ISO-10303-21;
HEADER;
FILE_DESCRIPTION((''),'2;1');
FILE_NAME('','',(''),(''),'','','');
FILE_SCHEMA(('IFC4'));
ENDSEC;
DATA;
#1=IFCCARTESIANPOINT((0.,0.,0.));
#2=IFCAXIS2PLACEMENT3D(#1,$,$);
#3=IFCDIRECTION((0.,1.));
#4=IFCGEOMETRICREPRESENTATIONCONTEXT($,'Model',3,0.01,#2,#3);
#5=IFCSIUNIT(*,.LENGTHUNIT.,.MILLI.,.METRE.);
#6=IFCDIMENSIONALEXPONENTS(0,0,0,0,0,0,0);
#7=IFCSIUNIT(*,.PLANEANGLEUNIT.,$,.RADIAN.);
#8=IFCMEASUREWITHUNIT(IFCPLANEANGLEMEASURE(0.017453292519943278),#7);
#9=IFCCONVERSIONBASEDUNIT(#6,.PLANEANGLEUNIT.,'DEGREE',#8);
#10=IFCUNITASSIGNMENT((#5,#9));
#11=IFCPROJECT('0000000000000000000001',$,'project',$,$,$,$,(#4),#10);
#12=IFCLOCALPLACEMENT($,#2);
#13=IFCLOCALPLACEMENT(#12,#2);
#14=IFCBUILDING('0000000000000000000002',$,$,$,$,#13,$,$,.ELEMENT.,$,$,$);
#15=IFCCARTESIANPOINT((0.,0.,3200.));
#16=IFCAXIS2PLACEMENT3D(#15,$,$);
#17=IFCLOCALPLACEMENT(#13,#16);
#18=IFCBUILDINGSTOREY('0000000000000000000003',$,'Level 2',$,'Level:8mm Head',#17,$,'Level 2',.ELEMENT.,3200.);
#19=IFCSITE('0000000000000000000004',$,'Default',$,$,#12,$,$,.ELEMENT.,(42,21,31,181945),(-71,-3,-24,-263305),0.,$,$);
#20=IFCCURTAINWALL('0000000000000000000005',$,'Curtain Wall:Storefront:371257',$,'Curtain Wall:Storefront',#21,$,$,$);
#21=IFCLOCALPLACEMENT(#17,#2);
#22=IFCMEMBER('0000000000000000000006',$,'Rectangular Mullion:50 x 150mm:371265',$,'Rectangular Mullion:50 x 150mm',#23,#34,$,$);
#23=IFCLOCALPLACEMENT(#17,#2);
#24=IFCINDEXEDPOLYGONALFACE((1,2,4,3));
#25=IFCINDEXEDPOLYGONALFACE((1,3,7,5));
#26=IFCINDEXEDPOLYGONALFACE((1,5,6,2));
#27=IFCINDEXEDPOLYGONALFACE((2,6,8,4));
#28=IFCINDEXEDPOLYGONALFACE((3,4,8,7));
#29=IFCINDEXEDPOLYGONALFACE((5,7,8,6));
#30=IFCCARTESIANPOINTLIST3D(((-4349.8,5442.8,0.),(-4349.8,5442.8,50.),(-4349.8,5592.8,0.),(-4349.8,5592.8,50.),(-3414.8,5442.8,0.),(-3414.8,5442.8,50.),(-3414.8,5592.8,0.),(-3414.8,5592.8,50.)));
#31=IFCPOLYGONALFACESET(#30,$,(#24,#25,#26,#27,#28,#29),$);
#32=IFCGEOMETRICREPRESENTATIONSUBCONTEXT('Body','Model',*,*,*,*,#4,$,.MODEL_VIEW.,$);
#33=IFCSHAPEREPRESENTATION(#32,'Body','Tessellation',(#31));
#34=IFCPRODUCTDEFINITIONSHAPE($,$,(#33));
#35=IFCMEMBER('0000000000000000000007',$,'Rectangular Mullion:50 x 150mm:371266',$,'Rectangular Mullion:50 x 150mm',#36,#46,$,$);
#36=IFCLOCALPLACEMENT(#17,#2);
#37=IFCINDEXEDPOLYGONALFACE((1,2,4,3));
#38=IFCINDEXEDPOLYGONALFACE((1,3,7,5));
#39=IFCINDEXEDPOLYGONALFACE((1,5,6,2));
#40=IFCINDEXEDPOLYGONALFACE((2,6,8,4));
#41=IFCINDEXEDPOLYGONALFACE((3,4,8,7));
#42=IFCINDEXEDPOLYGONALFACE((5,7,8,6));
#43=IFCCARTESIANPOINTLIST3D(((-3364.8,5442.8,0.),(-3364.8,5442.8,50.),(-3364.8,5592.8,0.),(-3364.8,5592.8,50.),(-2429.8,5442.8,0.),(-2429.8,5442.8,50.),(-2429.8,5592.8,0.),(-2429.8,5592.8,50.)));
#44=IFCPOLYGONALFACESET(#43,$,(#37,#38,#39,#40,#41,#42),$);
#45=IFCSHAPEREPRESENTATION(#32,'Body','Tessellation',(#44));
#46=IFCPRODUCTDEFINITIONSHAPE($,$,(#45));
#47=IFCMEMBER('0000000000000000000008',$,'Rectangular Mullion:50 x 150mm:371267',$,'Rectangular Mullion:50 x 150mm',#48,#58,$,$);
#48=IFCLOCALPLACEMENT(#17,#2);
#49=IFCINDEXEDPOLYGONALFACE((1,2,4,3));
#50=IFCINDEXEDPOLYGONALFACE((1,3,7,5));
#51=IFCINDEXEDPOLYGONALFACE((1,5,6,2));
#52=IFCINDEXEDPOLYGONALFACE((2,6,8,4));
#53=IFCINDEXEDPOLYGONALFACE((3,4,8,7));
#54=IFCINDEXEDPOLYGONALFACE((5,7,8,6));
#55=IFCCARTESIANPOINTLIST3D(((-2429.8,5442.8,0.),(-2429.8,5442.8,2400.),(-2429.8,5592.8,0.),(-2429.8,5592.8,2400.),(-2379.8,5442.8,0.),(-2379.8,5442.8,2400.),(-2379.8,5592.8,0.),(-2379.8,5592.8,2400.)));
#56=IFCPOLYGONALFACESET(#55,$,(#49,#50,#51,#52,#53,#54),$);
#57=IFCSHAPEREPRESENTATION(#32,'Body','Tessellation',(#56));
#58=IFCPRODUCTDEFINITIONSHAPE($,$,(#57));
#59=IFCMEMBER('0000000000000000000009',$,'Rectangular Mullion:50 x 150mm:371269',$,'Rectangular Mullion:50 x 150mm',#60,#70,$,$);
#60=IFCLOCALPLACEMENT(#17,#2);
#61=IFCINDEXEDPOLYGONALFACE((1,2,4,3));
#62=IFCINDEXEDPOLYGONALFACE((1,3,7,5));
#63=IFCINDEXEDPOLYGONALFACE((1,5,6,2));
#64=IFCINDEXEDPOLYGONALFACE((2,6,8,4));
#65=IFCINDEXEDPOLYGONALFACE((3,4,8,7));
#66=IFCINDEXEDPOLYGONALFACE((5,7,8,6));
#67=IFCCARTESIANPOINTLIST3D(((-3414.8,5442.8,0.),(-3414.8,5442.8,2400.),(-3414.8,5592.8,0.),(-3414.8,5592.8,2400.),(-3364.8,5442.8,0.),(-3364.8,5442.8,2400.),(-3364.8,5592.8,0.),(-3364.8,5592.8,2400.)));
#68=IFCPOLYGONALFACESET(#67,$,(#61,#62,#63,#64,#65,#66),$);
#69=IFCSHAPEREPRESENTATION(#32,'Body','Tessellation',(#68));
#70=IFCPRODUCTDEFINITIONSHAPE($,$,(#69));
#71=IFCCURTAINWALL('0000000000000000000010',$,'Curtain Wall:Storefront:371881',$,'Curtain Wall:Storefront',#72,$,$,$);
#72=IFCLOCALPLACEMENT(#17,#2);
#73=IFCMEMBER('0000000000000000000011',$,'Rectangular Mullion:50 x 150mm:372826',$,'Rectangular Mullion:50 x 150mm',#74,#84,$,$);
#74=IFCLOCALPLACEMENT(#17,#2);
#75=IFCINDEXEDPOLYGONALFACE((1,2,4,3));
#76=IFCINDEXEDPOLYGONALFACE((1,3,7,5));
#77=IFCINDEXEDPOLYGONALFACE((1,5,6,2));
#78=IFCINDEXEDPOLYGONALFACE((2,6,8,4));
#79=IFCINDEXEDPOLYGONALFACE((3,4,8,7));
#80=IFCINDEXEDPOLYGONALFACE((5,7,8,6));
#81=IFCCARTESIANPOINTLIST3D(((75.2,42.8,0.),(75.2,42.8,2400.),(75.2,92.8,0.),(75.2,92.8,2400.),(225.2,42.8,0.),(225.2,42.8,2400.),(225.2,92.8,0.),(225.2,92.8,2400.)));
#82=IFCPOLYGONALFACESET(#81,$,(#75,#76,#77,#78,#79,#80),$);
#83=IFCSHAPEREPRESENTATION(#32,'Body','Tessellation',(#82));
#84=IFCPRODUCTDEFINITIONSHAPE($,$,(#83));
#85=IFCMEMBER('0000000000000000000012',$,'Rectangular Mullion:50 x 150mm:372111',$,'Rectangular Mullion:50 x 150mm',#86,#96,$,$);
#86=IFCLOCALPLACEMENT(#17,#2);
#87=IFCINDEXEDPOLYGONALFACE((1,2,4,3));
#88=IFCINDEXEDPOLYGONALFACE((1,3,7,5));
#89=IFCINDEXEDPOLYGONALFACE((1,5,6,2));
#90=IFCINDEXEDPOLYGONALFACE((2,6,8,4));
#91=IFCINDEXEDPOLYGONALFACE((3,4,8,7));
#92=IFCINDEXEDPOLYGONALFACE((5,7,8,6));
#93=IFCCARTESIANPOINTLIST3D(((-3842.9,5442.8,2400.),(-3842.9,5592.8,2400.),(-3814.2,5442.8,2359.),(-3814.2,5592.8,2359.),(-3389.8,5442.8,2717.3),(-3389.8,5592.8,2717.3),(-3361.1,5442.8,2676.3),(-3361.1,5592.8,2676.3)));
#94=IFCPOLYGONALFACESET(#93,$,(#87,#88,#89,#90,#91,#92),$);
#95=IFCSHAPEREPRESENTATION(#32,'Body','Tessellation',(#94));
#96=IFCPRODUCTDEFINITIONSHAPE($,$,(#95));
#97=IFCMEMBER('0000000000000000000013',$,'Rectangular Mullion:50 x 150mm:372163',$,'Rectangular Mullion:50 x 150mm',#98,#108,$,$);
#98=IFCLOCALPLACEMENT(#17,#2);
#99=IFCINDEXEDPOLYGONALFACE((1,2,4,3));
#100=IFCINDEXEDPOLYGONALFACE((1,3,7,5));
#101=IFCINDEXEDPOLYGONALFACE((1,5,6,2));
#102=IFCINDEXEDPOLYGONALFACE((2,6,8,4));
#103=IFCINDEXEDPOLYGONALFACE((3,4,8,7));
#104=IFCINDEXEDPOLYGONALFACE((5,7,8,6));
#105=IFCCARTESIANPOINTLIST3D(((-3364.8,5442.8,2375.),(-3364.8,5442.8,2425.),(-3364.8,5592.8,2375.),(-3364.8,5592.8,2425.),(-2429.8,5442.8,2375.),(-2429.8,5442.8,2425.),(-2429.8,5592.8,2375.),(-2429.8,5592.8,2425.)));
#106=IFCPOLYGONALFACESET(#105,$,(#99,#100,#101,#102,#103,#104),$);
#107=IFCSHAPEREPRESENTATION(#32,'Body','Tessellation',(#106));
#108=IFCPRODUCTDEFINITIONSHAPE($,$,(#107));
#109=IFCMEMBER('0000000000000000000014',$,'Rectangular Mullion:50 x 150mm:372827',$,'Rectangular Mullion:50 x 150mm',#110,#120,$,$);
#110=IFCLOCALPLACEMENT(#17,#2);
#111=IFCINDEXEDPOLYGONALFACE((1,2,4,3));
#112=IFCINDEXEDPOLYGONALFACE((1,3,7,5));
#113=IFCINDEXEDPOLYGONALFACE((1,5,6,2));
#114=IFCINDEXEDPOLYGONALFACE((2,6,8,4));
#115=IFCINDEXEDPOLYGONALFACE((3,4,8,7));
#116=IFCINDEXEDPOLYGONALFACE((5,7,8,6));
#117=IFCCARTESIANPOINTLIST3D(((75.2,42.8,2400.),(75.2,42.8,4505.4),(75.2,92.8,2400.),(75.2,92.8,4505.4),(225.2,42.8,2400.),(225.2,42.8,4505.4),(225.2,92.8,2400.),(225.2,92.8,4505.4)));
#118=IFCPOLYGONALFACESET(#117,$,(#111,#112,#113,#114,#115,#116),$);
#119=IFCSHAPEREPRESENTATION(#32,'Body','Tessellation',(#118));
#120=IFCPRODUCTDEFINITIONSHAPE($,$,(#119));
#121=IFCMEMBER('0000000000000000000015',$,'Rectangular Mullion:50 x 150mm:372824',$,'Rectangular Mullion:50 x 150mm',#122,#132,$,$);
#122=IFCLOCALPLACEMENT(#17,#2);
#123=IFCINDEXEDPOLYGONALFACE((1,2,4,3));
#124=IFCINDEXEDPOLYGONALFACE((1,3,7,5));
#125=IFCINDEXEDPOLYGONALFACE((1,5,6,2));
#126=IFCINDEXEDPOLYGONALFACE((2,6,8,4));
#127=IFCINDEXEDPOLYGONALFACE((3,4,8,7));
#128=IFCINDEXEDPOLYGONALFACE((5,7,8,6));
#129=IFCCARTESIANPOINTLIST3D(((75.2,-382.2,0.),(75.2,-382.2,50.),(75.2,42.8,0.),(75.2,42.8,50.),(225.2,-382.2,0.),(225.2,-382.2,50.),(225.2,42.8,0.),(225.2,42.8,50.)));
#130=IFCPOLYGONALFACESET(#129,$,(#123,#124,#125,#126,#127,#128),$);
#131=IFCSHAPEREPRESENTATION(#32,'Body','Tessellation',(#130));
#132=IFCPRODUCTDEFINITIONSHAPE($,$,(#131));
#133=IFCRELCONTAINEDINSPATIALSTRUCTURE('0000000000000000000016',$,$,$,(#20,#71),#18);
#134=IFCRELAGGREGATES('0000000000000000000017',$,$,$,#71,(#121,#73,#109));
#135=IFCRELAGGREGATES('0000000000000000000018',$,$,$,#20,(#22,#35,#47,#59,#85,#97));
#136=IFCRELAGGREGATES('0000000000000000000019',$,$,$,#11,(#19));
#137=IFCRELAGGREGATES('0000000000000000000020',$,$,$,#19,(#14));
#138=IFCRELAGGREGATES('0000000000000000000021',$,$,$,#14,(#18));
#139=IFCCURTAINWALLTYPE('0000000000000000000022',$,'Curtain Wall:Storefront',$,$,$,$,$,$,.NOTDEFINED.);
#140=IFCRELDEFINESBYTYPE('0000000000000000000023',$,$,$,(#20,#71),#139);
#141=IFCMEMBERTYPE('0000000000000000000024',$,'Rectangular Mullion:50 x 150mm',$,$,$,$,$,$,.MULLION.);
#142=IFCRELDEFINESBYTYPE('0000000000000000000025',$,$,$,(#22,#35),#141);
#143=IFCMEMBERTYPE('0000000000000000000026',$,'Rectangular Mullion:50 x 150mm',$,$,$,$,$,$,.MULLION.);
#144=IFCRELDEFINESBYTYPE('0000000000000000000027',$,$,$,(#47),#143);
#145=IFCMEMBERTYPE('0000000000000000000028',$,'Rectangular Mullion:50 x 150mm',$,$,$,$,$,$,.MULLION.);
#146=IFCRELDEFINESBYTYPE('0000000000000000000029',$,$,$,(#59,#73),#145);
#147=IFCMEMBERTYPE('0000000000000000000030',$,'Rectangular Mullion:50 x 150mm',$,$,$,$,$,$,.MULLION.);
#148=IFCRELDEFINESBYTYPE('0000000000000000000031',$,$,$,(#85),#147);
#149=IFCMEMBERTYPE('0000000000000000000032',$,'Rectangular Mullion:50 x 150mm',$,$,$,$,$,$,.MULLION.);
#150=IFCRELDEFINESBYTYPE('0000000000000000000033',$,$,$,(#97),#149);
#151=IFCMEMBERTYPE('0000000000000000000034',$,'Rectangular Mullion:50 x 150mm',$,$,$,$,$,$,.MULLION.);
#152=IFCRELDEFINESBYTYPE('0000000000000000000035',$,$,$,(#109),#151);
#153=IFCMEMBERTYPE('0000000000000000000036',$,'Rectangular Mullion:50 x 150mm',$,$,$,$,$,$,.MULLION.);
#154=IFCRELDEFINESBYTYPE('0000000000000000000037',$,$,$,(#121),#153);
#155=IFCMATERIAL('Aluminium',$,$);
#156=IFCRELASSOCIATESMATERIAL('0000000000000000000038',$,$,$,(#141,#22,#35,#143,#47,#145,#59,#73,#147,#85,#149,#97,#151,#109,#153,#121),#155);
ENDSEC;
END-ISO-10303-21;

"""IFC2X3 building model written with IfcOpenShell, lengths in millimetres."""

from ifc_helpers import new_model, entity, si_unit, converted_unit, direction, frame, origin, origin_2d_with_axis, place, context, subcontext, project, spatial, rectangle, extrude, source, transform, mapped, material, type_object, type_shapes, element, aggregate, save


model = new_model("IFC2X3")

# Units and contexts
model_context = context("Model", 3, precision=0.01, world=origin(), true_north=direction((0.0, 1.0)))
body_context = subcontext(model_context, "Body", "Model", "MODEL_VIEW")
ifc_project = project(units=[si_unit("LENGTHUNIT", "METRE", prefix="MILLI"), converted_unit("PLANEANGLEUNIT", "DEGREE", entity("IfcPlaneAngleMeasure", 0.017453292519943278), si_unit("PLANEANGLEUNIT", "RADIAN"), dimensions=[0, 0, 0, 0, 0, 0, 0])], contexts=[model_context])

# Site, building, storey
site_placement = place(None, origin())
site = spatial("IfcSite", under=ifc_project, at=site_placement, Name="Default", CompositionType="ELEMENT", RefLatitude=(42, 21, 31, 181945), RefLongitude=(-71, -3, -24, -263305), RefElevation=0.0)
building_placement = place(site_placement, origin())
building = spatial("IfcBuilding", under=site, at=building_placement, CompositionType="ELEMENT")
storey_placement = place(building_placement, frame((0.0, 0.0, 3200.0)))
storey = spatial("IfcBuildingStorey", under=building, at=storey_placement, Name="Level 2", ObjectType="Level:8mm Head", LongName="Level 2", CompositionType="ELEMENT", Elevation=3200.0)

# Curtain wall, members
curtain_wall_type = type_object("IfcCurtainWallType", Name="Curtain Wall:Storefront", PredefinedType="NOTDEFINED")
curtain_wall_1_placement = place(storey_placement, frame((0.0, 0.0, -3200.0)))
curtain_wall_1 = element("IfcCurtainWall", 1, at=curtain_wall_1_placement, inside=storey, type_object=curtain_wall_type, Name="Curtain Wall:Storefront:371257", ObjectType="Curtain Wall:Storefront")
ifc_material_1 = material(Name="Aluminium")
member_type_1 = type_object("IfcMemberType", Name="Rectangular Mullion:50 x 150mm", PredefinedType="MULLION", material=ifc_material_1)
shared_shape_1 = source(origin(), body_context, "Body", "SweptSolid", [
    extrude(rectangle(XDim=50.0, YDim=150.0, at=origin_2d_with_axis()), frame((-25.0, 0.0, -935.0), z_axis=(0.0, 0.0, 1.0), x_axis=(-1.0, 0.0, 0.0)), (0.0, 0.0, 1.0), 935.0),
])
type_shapes(member_type_1, [shared_shape_1])
member_1_placement = place(curtain_wall_1_placement, frame((-4349.8, 5517.8, 3200.0), z_axis=(-1.0, 0.0, 0.0), x_axis=(0.0, 0.0, -1.0)))
member_1 = element("IfcMember", 2, at=member_1_placement, type_object=member_type_1, material=ifc_material_1, Name="Rectangular Mullion:50 x 150mm:371265", ObjectType="Rectangular Mullion:50 x 150mm", context=body_context, shape_type="MappedRepresentation", body=[
    mapped(shared_shape_1, transform((0.0, 0.0, 0.0), scale=1.0)),
])
member_2_placement = place(curtain_wall_1_placement, frame((-3364.8, 5517.8, 3200.0), z_axis=(-1.0, 0.0, 0.0), x_axis=(0.0, 0.0, -1.0)))
member_2 = element("IfcMember", 3, at=member_2_placement, type_object=member_type_1, material=ifc_material_1, Name="Rectangular Mullion:50 x 150mm:371266", ObjectType="Rectangular Mullion:50 x 150mm", context=body_context, shape_type="MappedRepresentation", body=[
    mapped(shared_shape_1, transform((0.0, 0.0, 0.0), scale=1.0)),
])
member_type_2 = type_object("IfcMemberType", Name="Rectangular Mullion:50 x 150mm", PredefinedType="MULLION", material=ifc_material_1)
shared_shape_2 = source(origin(), body_context, "Body", "SweptSolid", [
    extrude(rectangle(XDim=50.0, YDim=150.0, at=origin_2d_with_axis()), frame((-25.0, 0.0, -2400.0), z_axis=(0.0, 0.0, 1.0), x_axis=(-1.0, 0.0, 0.0)), (0.0, 0.0, 1.0), 2400.0),
])
type_shapes(member_type_2, [shared_shape_2])
member_3_placement = place(curtain_wall_1_placement, frame((-2379.8, 5517.8, 3200.0), z_axis=(0.0, 0.0, -1.0), x_axis=(1.0, 0.0, 0.0)))
member_3 = element("IfcMember", 4, at=member_3_placement, type_object=member_type_2, material=ifc_material_1, Name="Rectangular Mullion:50 x 150mm:371267", ObjectType="Rectangular Mullion:50 x 150mm", context=body_context, shape_type="MappedRepresentation", body=[
    mapped(shared_shape_2, transform((0.0, 0.0, 0.0), scale=1.0)),
])
member_type_3 = type_object("IfcMemberType", Name="Rectangular Mullion:50 x 150mm", PredefinedType="MULLION", material=ifc_material_1)
shared_shape_3 = source(origin(), body_context, "Body", "SweptSolid", [
    extrude(rectangle(XDim=50.0, YDim=150.0, at=origin_2d_with_axis()), frame((0.0, 0.0, -2400.0), z_axis=(0.0, 0.0, 1.0), x_axis=(-1.0, 0.0, 0.0)), (0.0, 0.0, 1.0), 2400.0),
])
type_shapes(member_type_3, [shared_shape_3])
member_4_placement = place(curtain_wall_1_placement, frame((-3389.8, 5517.8, 3200.0), z_axis=(0.0, 0.0, -1.0), x_axis=(1.0, 0.0, 0.0)))
member_4 = element("IfcMember", 5, at=member_4_placement, type_object=member_type_3, material=ifc_material_1, Name="Rectangular Mullion:50 x 150mm:371269", ObjectType="Rectangular Mullion:50 x 150mm", context=body_context, shape_type="MappedRepresentation", body=[
    mapped(shared_shape_3, transform((0.0, 0.0, 0.0), scale=1.0)),
])

# Curtain wall, member
curtain_wall_2_placement = place(storey_placement, frame((0.0, 0.0, -3200.0)))
curtain_wall_2 = element("IfcCurtainWall", 6, at=curtain_wall_2_placement, inside=storey, type_object=curtain_wall_type, Name="Curtain Wall:Storefront:371881", ObjectType="Curtain Wall:Storefront")
member_5_placement = place(curtain_wall_2_placement, frame((150.2, 67.8, 3200.0), z_axis=(0.0, 0.0, -1.0), x_axis=(0.0, -1.0, 0.0)))
member_5 = element("IfcMember", 7, at=member_5_placement, type_object=member_type_3, material=ifc_material_1, Name="Rectangular Mullion:50 x 150mm:372826", ObjectType="Rectangular Mullion:50 x 150mm", context=body_context, shape_type="MappedRepresentation", body=[
    mapped(shared_shape_3, transform((0.0, 0.0, 0.0), scale=1.0)),
])

# Members
member_type_4 = type_object("IfcMemberType", Name="Rectangular Mullion:50 x 150mm", PredefinedType="MULLION", material=ifc_material_1)
shared_shape_4 = source(origin(), body_context, "Body", "SweptSolid", [
    extrude(rectangle(XDim=50.0, YDim=150.0, at=origin_2d_with_axis()), frame((-25.0, 0.0, -553.1), z_axis=(0.0, 0.0, 1.0), x_axis=(-1.0, 0.0, 0.0)), (0.0, 0.0, 1.0), 553.1),
])
type_shapes(member_type_4, [shared_shape_4])
member_6_placement = place(curtain_wall_1_placement, frame((-3389.8, 5517.8, 5917.3), z_axis=(0.819152, 0.0, 0.573576), x_axis=(-0.573576, 0.0, 0.819152)))
member_6 = element("IfcMember", 8, at=member_6_placement, type_object=member_type_4, material=ifc_material_1, Name="Rectangular Mullion:50 x 150mm:372111", ObjectType="Rectangular Mullion:50 x 150mm", context=body_context, shape_type="MappedRepresentation", body=[
    mapped(shared_shape_4, transform((0.0, 0.0, 0.0), scale=1.0)),
])
member_type_5 = type_object("IfcMemberType", Name="Rectangular Mullion:50 x 150mm", PredefinedType="MULLION", material=ifc_material_1)
shared_shape_5 = source(origin(), body_context, "Body", "SweptSolid", [
    extrude(rectangle(XDim=50.0, YDim=150.0, at=origin_2d_with_axis()), frame((0.0, 0.0, -935.0), z_axis=(0.0, 0.0, 1.0), x_axis=(-1.0, 0.0, 0.0)), (0.0, 0.0, 1.0), 935.0),
])
type_shapes(member_type_5, [shared_shape_5])
member_7_placement = place(curtain_wall_1_placement, frame((-2429.8, 5517.8, 5600.0), z_axis=(1.0, 0.0, 0.0), x_axis=(0.0, 0.0, 1.0)))
member_7 = element("IfcMember", 9, at=member_7_placement, type_object=member_type_5, material=ifc_material_1, Name="Rectangular Mullion:50 x 150mm:372163", ObjectType="Rectangular Mullion:50 x 150mm", context=body_context, shape_type="MappedRepresentation", body=[
    mapped(shared_shape_5, transform((0.0, 0.0, 0.0), scale=1.0)),
])
member_type_6 = type_object("IfcMemberType", Name="Rectangular Mullion:50 x 150mm", PredefinedType="MULLION", material=ifc_material_1)
shared_shape_6 = source(origin(), body_context, "Body", "SweptSolid", [
    extrude(rectangle(XDim=50.0, YDim=150.0, at=origin_2d_with_axis()), frame((0.0, 0.0, -2105.4), z_axis=(0.0, 0.0, 1.0), x_axis=(-1.0, 0.0, 0.0)), (0.0, 0.0, 1.0), 2105.4),
])
type_shapes(member_type_6, [shared_shape_6])
member_8_placement = place(curtain_wall_2_placement, frame((150.2, 67.8, 5600.0), z_axis=(0.0, 0.0, -1.0), x_axis=(0.0, -1.0, 0.0)))
member_8 = element("IfcMember", 10, at=member_8_placement, type_object=member_type_6, material=ifc_material_1, Name="Rectangular Mullion:50 x 150mm:372827", ObjectType="Rectangular Mullion:50 x 150mm", context=body_context, shape_type="MappedRepresentation", body=[
    mapped(shared_shape_6, transform((0.0, 0.0, 0.0), scale=1.0)),
])
member_type_7 = type_object("IfcMemberType", Name="Rectangular Mullion:50 x 150mm", PredefinedType="MULLION", material=ifc_material_1)
shared_shape_7 = source(origin(), body_context, "Body", "SweptSolid", [
    extrude(rectangle(XDim=50.0, YDim=150.0, at=origin_2d_with_axis()), frame((-25.0, 0.0, -425.0), z_axis=(0.0, 0.0, 1.0), x_axis=(-1.0, 0.0, 0.0)), (0.0, 0.0, 1.0), 425.0),
])
type_shapes(member_type_7, [shared_shape_7])
member_9_placement = place(curtain_wall_2_placement, frame((150.2, 42.8, 3200.0), z_axis=(0.0, 1.0, 0.0), x_axis=(0.0, 0.0, -1.0)))
member_9 = element("IfcMember", 11, at=member_9_placement, type_object=member_type_7, material=ifc_material_1, Name="Rectangular Mullion:50 x 150mm:372824", ObjectType="Rectangular Mullion:50 x 150mm", context=body_context, shape_type="MappedRepresentation", body=[
    mapped(shared_shape_7, transform((0.0, 0.0, 0.0), scale=1.0)),
])
aggregate(curtain_wall_2, [member_9, member_5, member_8])

aggregate(curtain_wall_1, [member_1, member_2, member_3, member_4, member_6, member_7])

save(model, "model.ifc")
